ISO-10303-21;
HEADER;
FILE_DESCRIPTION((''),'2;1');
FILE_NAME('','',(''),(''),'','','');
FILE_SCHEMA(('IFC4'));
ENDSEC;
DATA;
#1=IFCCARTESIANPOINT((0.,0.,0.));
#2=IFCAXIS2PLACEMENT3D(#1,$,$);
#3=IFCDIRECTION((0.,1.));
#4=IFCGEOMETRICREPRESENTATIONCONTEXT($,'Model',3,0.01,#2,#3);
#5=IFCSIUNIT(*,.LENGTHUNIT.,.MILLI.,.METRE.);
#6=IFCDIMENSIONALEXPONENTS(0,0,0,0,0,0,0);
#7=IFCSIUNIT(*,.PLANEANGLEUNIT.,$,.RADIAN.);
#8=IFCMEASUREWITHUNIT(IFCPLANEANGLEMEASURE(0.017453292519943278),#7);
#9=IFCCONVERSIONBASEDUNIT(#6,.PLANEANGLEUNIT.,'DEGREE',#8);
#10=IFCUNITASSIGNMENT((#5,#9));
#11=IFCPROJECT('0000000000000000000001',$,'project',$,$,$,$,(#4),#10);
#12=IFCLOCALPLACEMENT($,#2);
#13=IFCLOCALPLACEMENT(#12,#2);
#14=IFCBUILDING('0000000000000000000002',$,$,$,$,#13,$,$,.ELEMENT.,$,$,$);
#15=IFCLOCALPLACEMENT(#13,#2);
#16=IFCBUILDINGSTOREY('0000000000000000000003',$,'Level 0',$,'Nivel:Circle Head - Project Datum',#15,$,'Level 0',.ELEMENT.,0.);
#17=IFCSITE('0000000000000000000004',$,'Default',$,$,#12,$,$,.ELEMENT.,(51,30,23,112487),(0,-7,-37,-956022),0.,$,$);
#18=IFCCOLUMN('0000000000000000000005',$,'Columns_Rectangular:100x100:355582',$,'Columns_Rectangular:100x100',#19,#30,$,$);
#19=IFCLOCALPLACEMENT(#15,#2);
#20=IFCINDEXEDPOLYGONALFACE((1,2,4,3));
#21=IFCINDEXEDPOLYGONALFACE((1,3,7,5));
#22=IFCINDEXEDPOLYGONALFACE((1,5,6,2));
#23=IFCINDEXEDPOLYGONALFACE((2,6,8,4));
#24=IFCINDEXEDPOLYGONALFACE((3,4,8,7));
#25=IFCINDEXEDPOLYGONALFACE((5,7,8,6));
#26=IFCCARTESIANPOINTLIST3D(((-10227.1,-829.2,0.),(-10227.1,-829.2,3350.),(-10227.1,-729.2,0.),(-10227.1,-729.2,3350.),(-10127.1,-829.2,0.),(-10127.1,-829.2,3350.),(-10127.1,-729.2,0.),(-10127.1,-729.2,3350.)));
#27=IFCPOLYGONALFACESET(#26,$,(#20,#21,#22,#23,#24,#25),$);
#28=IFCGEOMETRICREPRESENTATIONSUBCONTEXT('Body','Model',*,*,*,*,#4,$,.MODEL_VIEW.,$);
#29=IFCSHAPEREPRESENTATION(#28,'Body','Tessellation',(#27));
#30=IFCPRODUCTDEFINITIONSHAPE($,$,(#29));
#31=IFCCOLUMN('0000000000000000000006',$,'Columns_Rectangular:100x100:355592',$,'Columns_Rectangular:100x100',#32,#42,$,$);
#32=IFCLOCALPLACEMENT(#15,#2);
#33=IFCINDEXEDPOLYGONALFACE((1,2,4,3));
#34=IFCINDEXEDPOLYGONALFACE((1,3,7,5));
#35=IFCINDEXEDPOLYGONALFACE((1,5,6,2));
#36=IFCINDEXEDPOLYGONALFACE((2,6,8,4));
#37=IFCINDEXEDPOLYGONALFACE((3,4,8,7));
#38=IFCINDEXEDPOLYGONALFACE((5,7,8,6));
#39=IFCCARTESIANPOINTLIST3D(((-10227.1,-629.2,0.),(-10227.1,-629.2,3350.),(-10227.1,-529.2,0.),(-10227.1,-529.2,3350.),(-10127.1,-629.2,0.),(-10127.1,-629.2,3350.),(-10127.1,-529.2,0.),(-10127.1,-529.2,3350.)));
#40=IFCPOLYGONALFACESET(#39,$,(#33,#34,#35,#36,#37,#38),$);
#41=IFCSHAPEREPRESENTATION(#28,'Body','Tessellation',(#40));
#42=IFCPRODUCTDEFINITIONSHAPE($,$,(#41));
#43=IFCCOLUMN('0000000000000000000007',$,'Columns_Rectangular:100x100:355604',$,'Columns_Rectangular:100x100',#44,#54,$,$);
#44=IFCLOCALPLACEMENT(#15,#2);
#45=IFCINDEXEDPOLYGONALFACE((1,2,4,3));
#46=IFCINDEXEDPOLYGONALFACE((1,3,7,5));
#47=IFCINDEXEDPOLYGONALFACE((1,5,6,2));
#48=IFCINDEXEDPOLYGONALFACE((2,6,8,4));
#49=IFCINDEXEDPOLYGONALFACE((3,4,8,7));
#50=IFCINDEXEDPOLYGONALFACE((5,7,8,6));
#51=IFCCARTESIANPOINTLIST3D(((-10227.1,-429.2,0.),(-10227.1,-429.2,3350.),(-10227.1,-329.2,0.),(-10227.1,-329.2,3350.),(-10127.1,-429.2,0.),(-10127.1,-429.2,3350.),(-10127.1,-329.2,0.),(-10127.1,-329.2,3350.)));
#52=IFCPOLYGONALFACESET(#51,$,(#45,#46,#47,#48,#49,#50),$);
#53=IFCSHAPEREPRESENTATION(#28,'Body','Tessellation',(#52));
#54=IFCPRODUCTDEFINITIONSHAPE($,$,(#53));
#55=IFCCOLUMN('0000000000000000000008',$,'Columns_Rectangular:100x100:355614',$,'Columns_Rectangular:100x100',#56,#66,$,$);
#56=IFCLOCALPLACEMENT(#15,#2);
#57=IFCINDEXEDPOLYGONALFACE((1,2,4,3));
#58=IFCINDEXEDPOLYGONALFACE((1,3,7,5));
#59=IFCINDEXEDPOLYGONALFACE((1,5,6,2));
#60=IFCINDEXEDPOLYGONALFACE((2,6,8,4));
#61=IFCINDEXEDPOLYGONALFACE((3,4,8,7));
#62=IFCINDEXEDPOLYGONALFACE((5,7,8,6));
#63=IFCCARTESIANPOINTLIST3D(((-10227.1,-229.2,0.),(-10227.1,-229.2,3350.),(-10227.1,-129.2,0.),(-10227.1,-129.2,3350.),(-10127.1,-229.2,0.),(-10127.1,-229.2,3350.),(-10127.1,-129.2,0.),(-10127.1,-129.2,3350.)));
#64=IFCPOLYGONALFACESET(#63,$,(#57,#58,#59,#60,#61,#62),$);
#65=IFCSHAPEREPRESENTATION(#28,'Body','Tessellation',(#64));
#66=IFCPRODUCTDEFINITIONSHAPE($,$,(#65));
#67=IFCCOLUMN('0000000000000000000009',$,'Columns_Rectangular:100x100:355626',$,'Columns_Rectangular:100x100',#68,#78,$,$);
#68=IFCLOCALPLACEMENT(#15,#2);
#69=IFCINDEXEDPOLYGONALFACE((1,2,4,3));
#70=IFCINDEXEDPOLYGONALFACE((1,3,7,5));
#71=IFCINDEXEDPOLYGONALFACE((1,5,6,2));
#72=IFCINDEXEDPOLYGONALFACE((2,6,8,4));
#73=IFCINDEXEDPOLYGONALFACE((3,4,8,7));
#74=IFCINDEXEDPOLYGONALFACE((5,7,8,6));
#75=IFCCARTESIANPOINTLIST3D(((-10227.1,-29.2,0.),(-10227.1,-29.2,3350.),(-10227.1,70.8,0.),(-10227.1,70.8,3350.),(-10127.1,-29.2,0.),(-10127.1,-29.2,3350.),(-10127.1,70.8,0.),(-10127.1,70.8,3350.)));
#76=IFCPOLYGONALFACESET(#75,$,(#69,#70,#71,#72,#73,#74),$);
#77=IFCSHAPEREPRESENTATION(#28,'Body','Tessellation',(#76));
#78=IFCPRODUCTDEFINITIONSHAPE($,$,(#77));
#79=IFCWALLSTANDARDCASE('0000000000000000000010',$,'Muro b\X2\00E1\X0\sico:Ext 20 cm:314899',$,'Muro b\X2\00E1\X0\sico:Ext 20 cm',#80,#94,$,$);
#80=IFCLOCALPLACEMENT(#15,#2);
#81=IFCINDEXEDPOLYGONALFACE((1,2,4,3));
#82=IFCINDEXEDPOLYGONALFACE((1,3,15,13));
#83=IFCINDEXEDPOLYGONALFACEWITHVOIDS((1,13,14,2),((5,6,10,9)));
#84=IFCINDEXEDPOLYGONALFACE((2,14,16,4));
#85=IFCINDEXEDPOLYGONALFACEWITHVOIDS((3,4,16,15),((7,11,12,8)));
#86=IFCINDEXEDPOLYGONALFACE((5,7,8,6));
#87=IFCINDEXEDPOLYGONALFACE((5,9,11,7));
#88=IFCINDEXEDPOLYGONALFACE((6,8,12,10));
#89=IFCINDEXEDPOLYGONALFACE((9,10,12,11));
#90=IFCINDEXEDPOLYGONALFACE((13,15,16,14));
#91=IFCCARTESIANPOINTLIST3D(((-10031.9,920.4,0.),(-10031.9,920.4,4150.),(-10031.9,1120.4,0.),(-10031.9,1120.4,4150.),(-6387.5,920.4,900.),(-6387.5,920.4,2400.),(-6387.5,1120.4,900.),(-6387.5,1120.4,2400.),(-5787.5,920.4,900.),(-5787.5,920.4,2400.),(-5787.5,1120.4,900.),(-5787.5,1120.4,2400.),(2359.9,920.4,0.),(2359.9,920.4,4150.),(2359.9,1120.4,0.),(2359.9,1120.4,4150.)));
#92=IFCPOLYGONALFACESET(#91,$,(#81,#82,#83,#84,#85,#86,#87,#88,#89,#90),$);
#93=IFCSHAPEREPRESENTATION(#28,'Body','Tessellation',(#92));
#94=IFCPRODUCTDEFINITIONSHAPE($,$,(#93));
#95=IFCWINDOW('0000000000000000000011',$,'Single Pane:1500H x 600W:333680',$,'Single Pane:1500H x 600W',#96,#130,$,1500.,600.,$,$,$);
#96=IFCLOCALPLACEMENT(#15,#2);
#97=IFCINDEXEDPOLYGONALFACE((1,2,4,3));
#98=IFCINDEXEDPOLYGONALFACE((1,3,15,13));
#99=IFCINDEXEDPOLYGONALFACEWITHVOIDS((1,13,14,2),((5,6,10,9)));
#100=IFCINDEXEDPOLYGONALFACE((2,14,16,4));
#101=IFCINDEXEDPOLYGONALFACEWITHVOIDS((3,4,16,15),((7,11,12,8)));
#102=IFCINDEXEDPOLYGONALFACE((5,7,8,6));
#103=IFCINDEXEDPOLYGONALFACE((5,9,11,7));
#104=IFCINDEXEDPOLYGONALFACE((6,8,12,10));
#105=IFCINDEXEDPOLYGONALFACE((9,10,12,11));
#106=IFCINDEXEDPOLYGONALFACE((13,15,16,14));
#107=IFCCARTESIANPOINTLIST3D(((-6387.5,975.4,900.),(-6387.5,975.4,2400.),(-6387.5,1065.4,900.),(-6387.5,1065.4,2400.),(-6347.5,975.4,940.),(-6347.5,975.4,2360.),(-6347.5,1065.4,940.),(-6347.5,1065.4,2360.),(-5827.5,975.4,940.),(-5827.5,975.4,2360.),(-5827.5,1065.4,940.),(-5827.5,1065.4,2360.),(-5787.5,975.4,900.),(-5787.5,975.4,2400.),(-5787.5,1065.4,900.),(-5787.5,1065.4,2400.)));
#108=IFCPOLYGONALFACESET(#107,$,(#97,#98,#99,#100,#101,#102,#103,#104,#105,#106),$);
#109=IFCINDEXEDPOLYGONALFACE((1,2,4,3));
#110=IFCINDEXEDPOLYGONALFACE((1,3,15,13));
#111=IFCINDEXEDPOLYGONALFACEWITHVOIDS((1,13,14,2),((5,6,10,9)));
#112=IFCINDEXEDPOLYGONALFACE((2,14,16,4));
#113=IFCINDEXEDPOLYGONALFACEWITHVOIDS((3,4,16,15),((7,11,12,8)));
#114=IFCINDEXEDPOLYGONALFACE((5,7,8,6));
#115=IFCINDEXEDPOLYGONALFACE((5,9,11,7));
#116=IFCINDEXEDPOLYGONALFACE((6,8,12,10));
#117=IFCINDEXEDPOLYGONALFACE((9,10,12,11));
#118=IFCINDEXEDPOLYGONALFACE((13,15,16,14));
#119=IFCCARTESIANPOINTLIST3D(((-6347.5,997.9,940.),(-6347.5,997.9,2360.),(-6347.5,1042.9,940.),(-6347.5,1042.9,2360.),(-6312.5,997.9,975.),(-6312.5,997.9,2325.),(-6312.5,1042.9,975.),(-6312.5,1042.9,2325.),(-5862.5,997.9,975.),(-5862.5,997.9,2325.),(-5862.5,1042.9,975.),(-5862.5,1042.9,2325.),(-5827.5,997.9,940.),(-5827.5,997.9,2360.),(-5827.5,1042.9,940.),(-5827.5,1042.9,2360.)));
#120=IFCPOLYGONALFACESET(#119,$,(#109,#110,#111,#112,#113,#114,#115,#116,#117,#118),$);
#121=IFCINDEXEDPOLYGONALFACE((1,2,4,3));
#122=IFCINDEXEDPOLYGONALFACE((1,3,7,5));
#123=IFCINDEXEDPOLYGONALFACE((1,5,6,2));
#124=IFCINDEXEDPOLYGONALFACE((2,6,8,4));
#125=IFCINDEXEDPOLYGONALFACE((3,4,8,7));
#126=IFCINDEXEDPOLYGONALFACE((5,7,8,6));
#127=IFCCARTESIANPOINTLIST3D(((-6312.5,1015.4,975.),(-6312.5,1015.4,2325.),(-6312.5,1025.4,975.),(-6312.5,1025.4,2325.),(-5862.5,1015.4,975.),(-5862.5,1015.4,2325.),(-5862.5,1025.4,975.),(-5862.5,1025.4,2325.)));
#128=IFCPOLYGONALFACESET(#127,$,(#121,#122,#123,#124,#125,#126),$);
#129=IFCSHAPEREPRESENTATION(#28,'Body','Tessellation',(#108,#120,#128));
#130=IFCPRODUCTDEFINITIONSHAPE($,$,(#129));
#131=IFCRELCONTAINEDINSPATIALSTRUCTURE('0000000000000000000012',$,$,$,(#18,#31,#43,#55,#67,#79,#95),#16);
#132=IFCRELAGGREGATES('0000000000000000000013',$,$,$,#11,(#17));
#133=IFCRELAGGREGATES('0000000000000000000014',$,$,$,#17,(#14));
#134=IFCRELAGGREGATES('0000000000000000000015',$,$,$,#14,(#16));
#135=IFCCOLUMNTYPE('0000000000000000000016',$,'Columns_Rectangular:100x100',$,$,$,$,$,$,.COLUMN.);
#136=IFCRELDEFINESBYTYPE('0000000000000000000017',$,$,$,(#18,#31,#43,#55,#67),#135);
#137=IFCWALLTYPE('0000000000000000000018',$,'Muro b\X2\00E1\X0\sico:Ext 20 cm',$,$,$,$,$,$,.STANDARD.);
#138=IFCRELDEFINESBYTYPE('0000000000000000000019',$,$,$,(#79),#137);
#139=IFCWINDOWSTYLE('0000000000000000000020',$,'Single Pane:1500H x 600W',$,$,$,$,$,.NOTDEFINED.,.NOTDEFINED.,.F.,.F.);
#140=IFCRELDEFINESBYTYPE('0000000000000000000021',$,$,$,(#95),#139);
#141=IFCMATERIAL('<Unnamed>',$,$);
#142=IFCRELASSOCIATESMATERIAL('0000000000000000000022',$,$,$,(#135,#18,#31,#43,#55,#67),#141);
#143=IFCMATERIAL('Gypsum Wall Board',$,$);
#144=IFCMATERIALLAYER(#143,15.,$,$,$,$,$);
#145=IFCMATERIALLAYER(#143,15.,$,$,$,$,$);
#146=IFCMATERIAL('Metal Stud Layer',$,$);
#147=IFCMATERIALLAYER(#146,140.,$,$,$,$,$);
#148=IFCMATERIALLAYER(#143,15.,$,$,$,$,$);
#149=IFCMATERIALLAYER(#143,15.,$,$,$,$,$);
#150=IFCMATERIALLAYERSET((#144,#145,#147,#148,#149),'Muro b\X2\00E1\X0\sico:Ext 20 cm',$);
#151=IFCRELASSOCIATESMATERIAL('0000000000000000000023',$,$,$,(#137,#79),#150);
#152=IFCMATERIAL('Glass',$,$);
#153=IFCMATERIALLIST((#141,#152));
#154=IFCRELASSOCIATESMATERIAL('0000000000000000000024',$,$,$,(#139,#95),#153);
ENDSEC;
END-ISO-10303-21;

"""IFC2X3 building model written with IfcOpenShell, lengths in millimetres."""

from ifc_helpers import new_model, entity, si_unit, converted_unit, direction, frame, frame_2d, origin, origin_2d_with_axis, place, context, subcontext, project, spatial, polyline, rectangle, outline, extrude, source, transform, mapped, material, material_list, layer, layer_set, layer_usage, type_object, type_shapes, element, fill, save


model = new_model("IFC2X3")

# Units and contexts
model_context = context("Model", 3, precision=0.01, world=origin(), true_north=direction((0.0, 1.0)))
body_context = subcontext(model_context, "Body", "Model", "MODEL_VIEW")
ifc_project = project(units=[si_unit("LENGTHUNIT", "METRE", prefix="MILLI"), converted_unit("PLANEANGLEUNIT", "DEGREE", entity("IfcPlaneAngleMeasure", 0.017453292519943278), si_unit("PLANEANGLEUNIT", "RADIAN"), dimensions=[0, 0, 0, 0, 0, 0, 0])], contexts=[model_context])

# Site, building, storey
site_placement = place(None, origin())
site = spatial("IfcSite", under=ifc_project, at=site_placement, Name="Default", CompositionType="ELEMENT", RefLatitude=(51, 30, 23, 112487), RefLongitude=(0, -7, -37, -956022), RefElevation=0.0)
building_placement = place(site_placement, origin())
building = spatial("IfcBuilding", under=site, at=building_placement, CompositionType="ELEMENT")
storey_placement = place(building_placement, origin())
storey = spatial("IfcBuildingStorey", under=building, at=storey_placement, Name="Level 0", ObjectType="Nivel:Circle Head - Project Datum", LongName="Level 0", CompositionType="ELEMENT", Elevation=0.0)

# Columns
ifc_material_1 = material(Name="<Unnamed>")
column_type = type_object("IfcColumnType", Name="Columns_Rectangular:100x100", PredefinedType="COLUMN", material=ifc_material_1)
shared_shape_1 = source(origin(), body_context, "Body", "SweptSolid", [
    extrude(rectangle(XDim=100.0, YDim=100.0, at=origin_2d_with_axis()), frame((0.0, 0.0, 0.0), z_axis=(0.0, 0.0, 1.0), x_axis=(-1.0, 0.0, 0.0)), (0.0, 0.0, 1.0), 3350.0),
])
type_shapes(column_type, [shared_shape_1])
for number, where, name in (
    (1, (-10177.1, -779.2, 0.0), "Columns_Rectangular:100x100:355582"),
    (2, (-10177.1, -579.2, 0.0), "Columns_Rectangular:100x100:355592"),
    (3, (-10177.1, -379.2, 0.0), "Columns_Rectangular:100x100:355604"),
    (4, (-10177.1, -179.2, 0.0), "Columns_Rectangular:100x100:355614"),
    (5, (-10177.1, 20.8, 0.0), "Columns_Rectangular:100x100:355626"),
):
    element("IfcColumn", number, at=place(storey_placement, frame(where)), inside=storey, type_object=column_type, material=ifc_material_1, Name=name, ObjectType="Columns_Rectangular:100x100", context=body_context, shape_type="MappedRepresentation", body=[
        mapped(shared_shape_1, transform((0.0, 0.0, 0.0), scale=1.0)),
    ])

# Wall, openings, window
ifc_material_2 = material(Name="Gypsum Wall Board")
ifc_layer_1 = layer(ifc_material_2, 15.0)
ifc_layer_2 = layer(ifc_material_2, 15.0)
ifc_material_3 = material(Name="Metal Stud Layer")
ifc_layer_3 = layer(ifc_material_3, 140.0)
ifc_layer_4 = layer(ifc_material_2, 15.0)
ifc_layer_5 = layer(ifc_material_2, 15.0)
ifc_layer_set_1 = layer_set([ifc_layer_1, ifc_layer_2, ifc_layer_3, ifc_layer_4, ifc_layer_5], Name="Muro básico:Ext 20 cm")
ifc_layer_usage_1 = layer_usage(ifc_layer_set_1, "AXIS2", "NEGATIVE", 100.0)
wall_type_1 = type_object("IfcWallType", Name="Muro básico:Ext 20 cm", PredefinedType="STANDARD", material=ifc_layer_set_1)
wall_1_placement = place(storey_placement, frame((-10031.9, 1020.4, 0.0)))
wall_1 = element("IfcWallStandardCase", 6, at=wall_1_placement, inside=storey, type_object=wall_type_1, material=ifc_layer_usage_1, Name="Muro básico:Ext 20 cm:314899", ObjectType="Muro básico:Ext 20 cm", context=body_context, shape_type="SweptSolid", body=[
    extrude(rectangle(XDim=12391.8, YDim=200.0, at=frame_2d((6195.9, 0.0), x_axis=(-1.0, 0.0))), origin(), (0.0, 0.0, 1.0), 4150.0),
])
opening_1_placement = place(wall_1_placement, origin())
element("IfcOpeningElement", 7, at=opening_1_placement, cuts=wall_1, ObjectType="Opening", context=body_context, shape_type="SweptSolid", body=[
    extrude(rectangle(XDim=2110.0, YDim=200.0, at=frame_2d((0.0, 0.0), x_axis=(0.0, 1.0))), frame((4594.4, -910.0, 1055.0), z_axis=(0.0, 1.0, 0.0), x_axis=(-1.0, 0.0, 0.0)), (0.0, 0.0, 1.0), 810.0),
])
opening_2_placement = place(wall_1_placement, frame((3644.4, -100.0, 900.0)))
opening_2 = element("IfcOpeningElement", 8, at=opening_2_placement, cuts=wall_1, ObjectType="Opening", context=body_context, shape_type="SweptSolid", body=[
    extrude(rectangle(XDim=1500.0, YDim=600.0, at=frame_2d((750.0, 300.0), x_axis=(1.0, 0.0))), frame((0.0, 0.0, 0.0), z_axis=(0.0, 1.0, 0.0), x_axis=(0.0, 0.0, 1.0)), (0.0, 0.0, 1.0), 200.0),
])
ifc_material_4 = material(Name="Glass")
ifc_material_list_1 = material_list([ifc_material_1, ifc_material_4])
window_style_1 = type_object("IfcWindowStyle", Name="Single Pane:1500H x 600W", ConstructionType="NOTDEFINED", OperationType="NOTDEFINED", ParameterTakesPrecedence=False, Sizeable=False, material=ifc_material_list_1)
shared_shape_2 = source(origin(), body_context, "Body", "SweptSolid", [
    extrude(outline(polyline([(-300.0, -750.0), (300.0, -750.0), (300.0, 750.0), (-300.0, 750.0), (-300.0, -750.0)]), holes=[polyline([(-260.0, -710.0), (-260.0, 710.0), (260.0, 710.0), (260.0, -710.0), (-260.0, -710.0)])]), frame((300.0, 55.0, 750.0), z_axis=(0.0, 1.0, 0.0), x_axis=(1.0, 0.0, 0.0)), (0.0, 0.0, 1.0), 90.0),
    extrude(outline(polyline([(-260.0, -710.0), (260.0, -710.0), (260.0, 710.0), (-260.0, 710.0), (-260.0, -710.0)]), holes=[polyline([(-225.0, -675.0), (-225.0, 675.0), (225.0, 675.0), (225.0, -675.0), (-225.0, -675.0)])]), frame((300.0, 77.5, 750.0), z_axis=(0.0, 1.0, 0.0), x_axis=(1.0, 0.0, 0.0)), (0.0, 0.0, 1.0), 45.0),
    extrude(rectangle(XDim=10.0, YDim=450.0, at=origin_2d_with_axis()), frame((300.0, 100.0, 75.0), z_axis=(0.0, 0.0, 1.0), x_axis=(0.0, 1.0, 0.0)), (0.0, 0.0, 1.0), 1350.0),
])
type_shapes(window_style_1, [shared_shape_2])
window_1_placement = place(opening_2_placement, origin())
window_1 = element("IfcWindow", 9, at=window_1_placement, inside=storey, type_object=window_style_1, material=ifc_material_list_1, Name="Single Pane:1500H x 600W:333680", ObjectType="Single Pane:1500H x 600W", OverallHeight=1500.0, OverallWidth=600.0, context=body_context, shape_type="MappedRepresentation", body=[
    mapped(shared_shape_2, transform((0.0, 0.0, 0.0), scale=1.0)),
])
fill(opening_2, window_1)

save(model, "model.ifc")
